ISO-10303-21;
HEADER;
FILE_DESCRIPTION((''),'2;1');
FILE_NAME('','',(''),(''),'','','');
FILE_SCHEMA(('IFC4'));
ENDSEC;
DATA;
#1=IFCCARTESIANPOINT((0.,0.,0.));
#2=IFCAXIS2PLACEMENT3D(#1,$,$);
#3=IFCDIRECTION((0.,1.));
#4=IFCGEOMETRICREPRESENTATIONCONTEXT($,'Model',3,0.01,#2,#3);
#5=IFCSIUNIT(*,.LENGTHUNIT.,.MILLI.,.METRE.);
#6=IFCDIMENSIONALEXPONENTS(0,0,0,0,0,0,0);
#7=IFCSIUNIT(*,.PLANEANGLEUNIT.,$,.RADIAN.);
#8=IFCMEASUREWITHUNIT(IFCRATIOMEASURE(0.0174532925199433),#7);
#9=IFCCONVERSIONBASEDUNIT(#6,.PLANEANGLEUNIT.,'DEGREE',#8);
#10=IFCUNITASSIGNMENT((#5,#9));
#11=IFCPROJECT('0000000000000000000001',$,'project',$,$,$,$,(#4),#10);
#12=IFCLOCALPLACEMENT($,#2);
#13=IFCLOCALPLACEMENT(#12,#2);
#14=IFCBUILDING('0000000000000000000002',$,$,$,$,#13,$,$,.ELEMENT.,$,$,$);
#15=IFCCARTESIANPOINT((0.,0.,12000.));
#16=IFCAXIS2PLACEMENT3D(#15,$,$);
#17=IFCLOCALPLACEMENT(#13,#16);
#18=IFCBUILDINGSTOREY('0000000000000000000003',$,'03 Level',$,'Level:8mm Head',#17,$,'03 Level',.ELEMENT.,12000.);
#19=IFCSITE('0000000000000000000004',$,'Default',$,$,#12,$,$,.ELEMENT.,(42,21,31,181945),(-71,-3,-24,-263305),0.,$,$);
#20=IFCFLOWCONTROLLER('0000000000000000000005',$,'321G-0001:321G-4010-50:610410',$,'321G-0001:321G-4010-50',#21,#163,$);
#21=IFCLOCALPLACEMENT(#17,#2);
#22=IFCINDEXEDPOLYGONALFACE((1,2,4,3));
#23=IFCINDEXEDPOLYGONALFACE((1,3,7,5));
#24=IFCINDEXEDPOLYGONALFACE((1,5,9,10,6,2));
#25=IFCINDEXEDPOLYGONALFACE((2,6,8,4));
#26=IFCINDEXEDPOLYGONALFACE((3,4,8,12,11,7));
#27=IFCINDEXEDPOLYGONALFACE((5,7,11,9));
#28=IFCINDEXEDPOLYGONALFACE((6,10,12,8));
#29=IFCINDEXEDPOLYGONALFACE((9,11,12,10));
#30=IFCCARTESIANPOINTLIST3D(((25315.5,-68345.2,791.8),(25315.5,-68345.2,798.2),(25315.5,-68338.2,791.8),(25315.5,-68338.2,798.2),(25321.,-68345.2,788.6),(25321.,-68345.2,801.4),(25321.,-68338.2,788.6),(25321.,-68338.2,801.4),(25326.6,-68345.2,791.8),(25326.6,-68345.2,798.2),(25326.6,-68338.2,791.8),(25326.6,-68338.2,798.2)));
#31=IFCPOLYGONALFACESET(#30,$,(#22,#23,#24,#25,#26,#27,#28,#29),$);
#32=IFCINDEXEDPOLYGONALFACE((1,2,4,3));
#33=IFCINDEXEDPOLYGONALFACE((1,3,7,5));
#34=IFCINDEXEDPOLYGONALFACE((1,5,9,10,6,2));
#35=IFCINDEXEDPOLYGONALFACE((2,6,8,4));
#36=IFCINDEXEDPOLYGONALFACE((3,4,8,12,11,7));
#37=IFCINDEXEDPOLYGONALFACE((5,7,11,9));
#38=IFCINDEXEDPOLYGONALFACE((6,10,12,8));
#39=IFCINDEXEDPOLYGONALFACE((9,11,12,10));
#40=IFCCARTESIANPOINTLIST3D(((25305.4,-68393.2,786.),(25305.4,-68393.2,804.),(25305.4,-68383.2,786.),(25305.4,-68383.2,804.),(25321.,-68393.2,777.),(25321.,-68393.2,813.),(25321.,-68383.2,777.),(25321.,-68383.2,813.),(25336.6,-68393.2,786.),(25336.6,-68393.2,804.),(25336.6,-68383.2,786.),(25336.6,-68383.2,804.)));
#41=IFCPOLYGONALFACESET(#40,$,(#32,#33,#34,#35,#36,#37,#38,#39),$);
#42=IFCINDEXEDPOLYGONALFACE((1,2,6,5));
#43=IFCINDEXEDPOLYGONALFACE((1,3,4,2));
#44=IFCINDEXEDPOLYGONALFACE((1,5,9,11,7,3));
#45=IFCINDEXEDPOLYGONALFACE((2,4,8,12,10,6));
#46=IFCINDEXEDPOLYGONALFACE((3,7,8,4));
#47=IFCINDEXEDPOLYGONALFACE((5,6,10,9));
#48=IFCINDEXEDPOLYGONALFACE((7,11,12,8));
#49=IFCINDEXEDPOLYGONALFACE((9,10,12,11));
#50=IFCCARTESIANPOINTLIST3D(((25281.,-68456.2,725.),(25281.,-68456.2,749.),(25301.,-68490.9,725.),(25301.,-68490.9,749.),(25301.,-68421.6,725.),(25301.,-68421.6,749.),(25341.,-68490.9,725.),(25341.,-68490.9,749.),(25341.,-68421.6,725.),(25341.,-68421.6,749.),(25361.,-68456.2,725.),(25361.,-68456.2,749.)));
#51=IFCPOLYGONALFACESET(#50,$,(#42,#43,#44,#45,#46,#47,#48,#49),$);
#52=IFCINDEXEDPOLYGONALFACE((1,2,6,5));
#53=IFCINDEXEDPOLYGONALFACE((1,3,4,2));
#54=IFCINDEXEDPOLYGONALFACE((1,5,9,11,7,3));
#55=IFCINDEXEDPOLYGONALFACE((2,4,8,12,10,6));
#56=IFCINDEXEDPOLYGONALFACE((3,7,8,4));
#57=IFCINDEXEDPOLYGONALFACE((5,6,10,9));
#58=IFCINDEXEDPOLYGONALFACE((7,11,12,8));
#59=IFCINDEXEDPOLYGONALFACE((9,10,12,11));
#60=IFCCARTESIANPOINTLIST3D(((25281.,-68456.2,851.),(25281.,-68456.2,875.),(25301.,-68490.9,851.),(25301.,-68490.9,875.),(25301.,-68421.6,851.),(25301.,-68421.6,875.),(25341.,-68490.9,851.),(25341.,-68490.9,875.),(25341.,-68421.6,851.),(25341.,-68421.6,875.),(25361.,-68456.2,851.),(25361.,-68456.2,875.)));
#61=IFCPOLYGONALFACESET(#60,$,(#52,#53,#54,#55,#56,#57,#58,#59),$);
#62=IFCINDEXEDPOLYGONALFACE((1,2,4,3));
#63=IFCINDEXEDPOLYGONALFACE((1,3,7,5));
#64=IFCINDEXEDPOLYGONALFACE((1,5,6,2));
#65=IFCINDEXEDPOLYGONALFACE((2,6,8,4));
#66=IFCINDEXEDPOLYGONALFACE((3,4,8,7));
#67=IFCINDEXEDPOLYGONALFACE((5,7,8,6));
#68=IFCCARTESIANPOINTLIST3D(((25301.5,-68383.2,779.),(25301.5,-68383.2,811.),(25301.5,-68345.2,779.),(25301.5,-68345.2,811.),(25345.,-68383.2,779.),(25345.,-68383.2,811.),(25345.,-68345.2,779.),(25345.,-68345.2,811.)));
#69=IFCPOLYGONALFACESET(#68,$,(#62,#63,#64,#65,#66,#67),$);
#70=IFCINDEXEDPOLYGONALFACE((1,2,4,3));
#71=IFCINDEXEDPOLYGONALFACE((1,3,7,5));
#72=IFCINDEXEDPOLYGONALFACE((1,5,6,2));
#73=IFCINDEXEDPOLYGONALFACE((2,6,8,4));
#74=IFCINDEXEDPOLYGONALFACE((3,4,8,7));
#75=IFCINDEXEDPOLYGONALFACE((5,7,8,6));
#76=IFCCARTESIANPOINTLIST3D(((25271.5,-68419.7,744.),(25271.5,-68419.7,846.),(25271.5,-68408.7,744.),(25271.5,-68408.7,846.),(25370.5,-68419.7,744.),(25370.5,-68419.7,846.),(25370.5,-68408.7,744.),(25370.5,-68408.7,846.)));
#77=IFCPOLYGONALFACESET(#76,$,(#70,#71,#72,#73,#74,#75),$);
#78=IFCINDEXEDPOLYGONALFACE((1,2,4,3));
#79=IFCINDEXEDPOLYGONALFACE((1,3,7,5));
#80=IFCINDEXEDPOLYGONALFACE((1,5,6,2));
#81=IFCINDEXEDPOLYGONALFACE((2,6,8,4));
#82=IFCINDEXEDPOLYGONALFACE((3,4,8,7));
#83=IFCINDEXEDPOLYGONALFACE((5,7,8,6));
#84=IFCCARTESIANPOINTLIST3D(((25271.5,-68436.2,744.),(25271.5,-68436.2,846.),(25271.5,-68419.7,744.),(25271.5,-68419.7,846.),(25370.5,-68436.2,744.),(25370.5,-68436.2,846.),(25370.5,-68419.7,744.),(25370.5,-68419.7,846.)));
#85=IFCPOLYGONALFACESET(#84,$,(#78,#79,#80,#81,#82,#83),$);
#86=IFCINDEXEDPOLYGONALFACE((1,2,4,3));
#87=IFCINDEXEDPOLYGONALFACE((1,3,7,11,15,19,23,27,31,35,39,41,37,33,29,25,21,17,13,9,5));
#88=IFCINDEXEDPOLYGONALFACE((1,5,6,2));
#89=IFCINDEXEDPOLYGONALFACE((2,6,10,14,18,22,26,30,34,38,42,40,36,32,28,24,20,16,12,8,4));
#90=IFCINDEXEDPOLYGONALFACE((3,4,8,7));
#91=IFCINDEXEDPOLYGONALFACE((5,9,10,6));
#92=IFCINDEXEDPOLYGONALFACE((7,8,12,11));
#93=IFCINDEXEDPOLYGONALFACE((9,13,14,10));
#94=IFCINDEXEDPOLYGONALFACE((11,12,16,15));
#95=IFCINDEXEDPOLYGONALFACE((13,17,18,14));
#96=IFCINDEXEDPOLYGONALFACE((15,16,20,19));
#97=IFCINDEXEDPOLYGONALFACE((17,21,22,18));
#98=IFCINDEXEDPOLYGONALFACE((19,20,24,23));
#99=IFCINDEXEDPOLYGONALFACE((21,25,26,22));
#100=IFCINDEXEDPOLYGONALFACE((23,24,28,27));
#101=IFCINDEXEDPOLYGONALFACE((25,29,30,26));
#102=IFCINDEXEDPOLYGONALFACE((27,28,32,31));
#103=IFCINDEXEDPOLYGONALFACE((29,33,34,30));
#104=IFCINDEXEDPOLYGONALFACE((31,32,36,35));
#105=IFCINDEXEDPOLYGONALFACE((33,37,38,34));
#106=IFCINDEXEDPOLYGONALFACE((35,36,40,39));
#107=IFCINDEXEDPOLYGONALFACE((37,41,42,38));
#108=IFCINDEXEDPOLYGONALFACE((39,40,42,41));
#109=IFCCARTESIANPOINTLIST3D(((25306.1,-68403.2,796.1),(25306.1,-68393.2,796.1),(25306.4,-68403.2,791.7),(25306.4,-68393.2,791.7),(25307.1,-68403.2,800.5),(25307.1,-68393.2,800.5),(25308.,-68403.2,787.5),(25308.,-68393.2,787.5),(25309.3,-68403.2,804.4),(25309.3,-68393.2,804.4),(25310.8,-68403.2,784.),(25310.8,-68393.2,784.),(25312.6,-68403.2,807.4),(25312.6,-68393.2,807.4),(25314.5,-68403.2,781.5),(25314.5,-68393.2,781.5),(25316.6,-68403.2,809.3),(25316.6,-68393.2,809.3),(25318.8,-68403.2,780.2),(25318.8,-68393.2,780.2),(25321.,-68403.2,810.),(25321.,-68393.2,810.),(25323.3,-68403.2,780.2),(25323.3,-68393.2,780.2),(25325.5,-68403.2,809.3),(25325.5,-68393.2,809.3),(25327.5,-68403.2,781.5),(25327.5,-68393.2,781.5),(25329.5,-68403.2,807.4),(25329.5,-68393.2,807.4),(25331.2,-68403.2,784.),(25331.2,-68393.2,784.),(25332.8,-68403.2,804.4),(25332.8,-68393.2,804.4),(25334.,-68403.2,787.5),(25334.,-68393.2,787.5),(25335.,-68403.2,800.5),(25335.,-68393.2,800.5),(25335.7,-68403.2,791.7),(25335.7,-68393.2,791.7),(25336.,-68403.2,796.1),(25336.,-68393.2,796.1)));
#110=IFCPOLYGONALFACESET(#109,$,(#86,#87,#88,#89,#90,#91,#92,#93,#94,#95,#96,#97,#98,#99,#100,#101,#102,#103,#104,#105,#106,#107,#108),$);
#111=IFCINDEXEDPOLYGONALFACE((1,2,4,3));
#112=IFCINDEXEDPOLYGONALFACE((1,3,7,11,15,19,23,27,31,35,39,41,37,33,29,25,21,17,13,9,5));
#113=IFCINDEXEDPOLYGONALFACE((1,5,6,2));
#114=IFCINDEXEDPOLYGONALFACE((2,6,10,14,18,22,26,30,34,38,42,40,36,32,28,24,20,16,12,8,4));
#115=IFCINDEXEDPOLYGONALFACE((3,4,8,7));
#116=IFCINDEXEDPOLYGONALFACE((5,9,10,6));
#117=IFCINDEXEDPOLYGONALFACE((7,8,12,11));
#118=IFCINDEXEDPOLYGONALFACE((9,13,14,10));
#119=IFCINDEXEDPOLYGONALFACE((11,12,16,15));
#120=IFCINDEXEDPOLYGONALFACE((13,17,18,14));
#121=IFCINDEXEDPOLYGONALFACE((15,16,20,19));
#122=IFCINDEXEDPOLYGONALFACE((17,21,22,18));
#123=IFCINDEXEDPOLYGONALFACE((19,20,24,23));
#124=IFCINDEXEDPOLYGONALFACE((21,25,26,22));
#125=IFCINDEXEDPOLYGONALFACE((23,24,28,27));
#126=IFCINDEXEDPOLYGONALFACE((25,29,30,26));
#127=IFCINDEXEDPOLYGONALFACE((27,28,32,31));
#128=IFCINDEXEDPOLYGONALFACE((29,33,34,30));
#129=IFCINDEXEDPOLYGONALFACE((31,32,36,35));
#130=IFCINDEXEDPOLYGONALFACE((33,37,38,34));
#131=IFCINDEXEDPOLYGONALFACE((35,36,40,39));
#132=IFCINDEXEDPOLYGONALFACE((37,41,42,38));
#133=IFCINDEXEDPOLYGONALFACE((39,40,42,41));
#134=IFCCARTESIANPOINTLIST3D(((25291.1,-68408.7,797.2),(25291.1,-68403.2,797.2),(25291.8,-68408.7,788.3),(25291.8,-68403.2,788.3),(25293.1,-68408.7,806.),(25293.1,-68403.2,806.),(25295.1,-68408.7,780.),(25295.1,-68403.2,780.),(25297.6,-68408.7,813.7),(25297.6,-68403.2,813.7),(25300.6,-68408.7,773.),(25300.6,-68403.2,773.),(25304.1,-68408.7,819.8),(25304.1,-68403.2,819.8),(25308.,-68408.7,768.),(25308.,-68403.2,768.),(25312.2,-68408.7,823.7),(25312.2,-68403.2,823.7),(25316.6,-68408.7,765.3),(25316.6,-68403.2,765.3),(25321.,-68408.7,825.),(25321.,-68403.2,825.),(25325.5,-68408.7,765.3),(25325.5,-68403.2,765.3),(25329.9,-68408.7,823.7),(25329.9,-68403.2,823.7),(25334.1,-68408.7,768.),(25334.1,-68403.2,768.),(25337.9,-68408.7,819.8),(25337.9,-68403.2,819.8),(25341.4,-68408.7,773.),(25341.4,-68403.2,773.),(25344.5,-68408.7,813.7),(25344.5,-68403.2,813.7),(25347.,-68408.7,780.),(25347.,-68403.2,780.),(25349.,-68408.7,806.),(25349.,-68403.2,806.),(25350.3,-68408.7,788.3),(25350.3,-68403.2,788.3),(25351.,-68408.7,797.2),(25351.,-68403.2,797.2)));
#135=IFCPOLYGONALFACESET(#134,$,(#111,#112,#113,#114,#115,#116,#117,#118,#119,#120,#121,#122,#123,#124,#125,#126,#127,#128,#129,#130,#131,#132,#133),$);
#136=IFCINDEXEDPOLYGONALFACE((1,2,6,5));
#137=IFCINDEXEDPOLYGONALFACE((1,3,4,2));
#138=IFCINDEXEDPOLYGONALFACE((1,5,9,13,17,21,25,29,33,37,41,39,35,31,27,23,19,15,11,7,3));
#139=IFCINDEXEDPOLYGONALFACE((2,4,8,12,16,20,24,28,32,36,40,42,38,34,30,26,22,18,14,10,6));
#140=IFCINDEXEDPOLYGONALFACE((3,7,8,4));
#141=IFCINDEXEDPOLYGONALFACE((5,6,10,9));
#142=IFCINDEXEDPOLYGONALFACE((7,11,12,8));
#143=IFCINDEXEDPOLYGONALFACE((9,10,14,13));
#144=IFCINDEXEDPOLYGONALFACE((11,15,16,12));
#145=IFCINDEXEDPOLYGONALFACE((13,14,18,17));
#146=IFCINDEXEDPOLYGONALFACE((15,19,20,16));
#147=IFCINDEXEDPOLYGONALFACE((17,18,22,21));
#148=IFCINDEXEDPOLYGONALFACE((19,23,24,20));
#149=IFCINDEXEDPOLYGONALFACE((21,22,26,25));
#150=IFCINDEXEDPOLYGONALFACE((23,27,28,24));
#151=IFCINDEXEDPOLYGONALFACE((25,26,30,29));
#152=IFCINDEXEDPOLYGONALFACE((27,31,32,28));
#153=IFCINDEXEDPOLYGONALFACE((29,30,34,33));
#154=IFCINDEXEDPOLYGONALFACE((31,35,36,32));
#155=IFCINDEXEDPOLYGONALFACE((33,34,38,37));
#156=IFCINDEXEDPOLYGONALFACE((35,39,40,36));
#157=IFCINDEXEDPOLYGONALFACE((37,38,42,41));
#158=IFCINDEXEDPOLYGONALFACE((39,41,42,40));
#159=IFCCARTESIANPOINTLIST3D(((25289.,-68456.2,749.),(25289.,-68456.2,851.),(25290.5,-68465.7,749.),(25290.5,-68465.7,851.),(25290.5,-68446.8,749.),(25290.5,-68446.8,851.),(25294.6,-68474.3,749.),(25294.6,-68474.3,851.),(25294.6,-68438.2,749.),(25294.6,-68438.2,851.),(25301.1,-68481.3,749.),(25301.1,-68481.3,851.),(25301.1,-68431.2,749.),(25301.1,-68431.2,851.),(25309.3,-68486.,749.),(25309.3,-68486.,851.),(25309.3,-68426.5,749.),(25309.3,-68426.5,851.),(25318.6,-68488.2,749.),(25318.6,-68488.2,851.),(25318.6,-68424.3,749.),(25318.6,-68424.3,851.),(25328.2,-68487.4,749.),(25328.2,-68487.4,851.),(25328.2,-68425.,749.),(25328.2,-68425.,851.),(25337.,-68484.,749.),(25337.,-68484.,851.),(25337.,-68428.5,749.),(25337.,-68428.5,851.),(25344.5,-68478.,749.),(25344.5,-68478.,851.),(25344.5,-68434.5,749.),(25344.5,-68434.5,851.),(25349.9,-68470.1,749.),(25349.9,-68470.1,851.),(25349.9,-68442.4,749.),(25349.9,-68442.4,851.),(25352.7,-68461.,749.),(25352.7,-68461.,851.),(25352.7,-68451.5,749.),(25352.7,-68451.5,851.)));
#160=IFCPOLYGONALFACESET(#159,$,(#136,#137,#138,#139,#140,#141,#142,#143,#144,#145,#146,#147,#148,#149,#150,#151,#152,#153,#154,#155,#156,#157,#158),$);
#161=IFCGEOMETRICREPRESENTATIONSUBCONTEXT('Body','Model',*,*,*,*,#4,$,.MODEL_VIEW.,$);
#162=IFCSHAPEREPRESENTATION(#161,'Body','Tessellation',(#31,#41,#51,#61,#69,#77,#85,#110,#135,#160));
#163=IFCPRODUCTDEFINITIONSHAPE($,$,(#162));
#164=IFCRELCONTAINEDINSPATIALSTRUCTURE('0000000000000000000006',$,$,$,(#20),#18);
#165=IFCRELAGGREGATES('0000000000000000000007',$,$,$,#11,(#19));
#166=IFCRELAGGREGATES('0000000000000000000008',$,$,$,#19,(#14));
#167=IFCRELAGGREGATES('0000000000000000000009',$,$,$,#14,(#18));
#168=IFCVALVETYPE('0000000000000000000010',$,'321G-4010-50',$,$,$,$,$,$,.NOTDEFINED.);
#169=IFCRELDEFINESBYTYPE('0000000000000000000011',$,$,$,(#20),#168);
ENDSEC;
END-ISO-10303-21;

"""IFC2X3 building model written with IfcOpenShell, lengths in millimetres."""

from ifc_helpers import new_model, entity, si_unit, converted_unit, direction, frame, frame_2d, origin, origin_2d_with_axis, place, context, subcontext, project, spatial, polyline, rectangle, circle, outline, extrude, source, transform, mapped, type_object, type_shapes, element, save


model = new_model("IFC2X3")

# Units and contexts
model_context = context("Model", 3, precision=0.01, world=origin(), true_north=direction((0.0, 1.0)))
body_context = subcontext(model_context, "Body", "Model", "MODEL_VIEW")
ifc_project = project(units=[si_unit("LENGTHUNIT", "METRE", prefix="MILLI"), converted_unit("PLANEANGLEUNIT", "DEGREE", entity("IfcRatioMeasure", 0.0174532925199433), si_unit("PLANEANGLEUNIT", "RADIAN"), dimensions=[0, 0, 0, 0, 0, 0, 0])], contexts=[model_context])

# Site, building, storey
site_placement = place(None, origin())
site = spatial("IfcSite", under=ifc_project, at=site_placement, Name="Default", CompositionType="ELEMENT", RefLatitude=(42, 21, 31, 181945), RefLongitude=(-71, -3, -24, -263305), RefElevation=0.0)
building_placement = place(site_placement, origin())
building = spatial("IfcBuilding", under=site, at=building_placement, CompositionType="ELEMENT")
storey_placement = place(building_placement, frame((0.0, 0.0, 12000.0)))
storey = spatial("IfcBuildingStorey", under=building, at=storey_placement, Name="03 Level", ObjectType="Level:8mm Head", LongName="03 Level", CompositionType="ELEMENT", Elevation=12000.0)

# Flow controller
valve_type_1 = type_object("IfcValveType", Name="321G-4010-50", PredefinedType="NOTDEFINED")
shared_shape_1 = source(origin(), body_context, "Body", "SweptSolid", [
    extrude(outline(polyline([(-3.2, -5.5), (3.2, -5.5), (6.4, 0.0), (3.2, 5.5), (-3.2, 5.5), (-6.4, 0.0), (-3.2, -5.5)])), frame((-5.0, 0.0, 111.0), z_axis=(0.0, 0.0, 1.0), x_axis=(0.5, 0.866025, 0.0)), (0.0, 0.0, 1.0), 7.0),
    extrude(outline(polyline([(-9.0, -15.6), (9.0, -15.6), (18.0, 0.0), (9.0, 15.6), (-9.0, 15.6), (-18.0, 0.0), (-9.0, -15.6)])), frame((-5.0, 0.0, 63.0), z_axis=(0.0, 0.0, 1.0), x_axis=(0.5, 0.866025, 0.0)), (0.0, 0.0, 1.0), 10.0),
    extrude(outline(polyline([(-20.0, -34.6), (20.0, -34.6), (40.0, 0.0), (20.0, 34.6), (-20.0, 34.6), (-40.0, 0.0), (-20.0, -34.6)])), frame((-75.0, 0.0, 0.0), z_axis=(1.0, 0.0, 0.0), x_axis=(0.0, -0.5, -0.866025)), (0.0, 0.0, 1.0), 24.0),
    extrude(outline(polyline([(-20.0, -34.6), (20.0, -34.6), (40.0, 0.0), (20.0, 34.6), (-20.0, 34.6), (-40.0, 0.0), (-20.0, -34.6)])), frame((51.0, 0.0, 0.0), z_axis=(1.0, 0.0, 0.0), x_axis=(0.0, -0.5, -0.866025)), (0.0, 0.0, 1.0), 24.0),
    extrude(rectangle(XDim=43.5, YDim=32.0, at=frame_2d((0.0, 0.0), x_axis=(1.0, 0.0))), frame((-5.0, 2.2, 73.0), z_axis=(0.0, 0.0, 1.0), x_axis=(0.0, -1.0, 0.0)), (0.0, 0.0, 1.0), 38.0),
    extrude(rectangle(XDim=99.0, YDim=102.0, at=origin_2d_with_axis()), frame((-5.0, 0.0, 36.5), z_axis=(0.0, 0.0, 1.0), x_axis=(0.0, -1.0, 0.0)), (0.0, 0.0, 1.0), 11.0),
    extrude(rectangle(XDim=99.0, YDim=102.0, at=origin_2d_with_axis()), frame((-5.0, 0.0, 20.0), z_axis=(0.0, 0.0, 1.0), x_axis=(0.0, -1.0, 0.0)), (0.0, 0.0, 1.0), 16.5),
    extrude(circle(Radius=15.0, at=frame_2d((0.0, 0.0), x_axis=(1.0, 0.0))), frame((-5.0, 0.0, 53.0)), (0.0, 0.0, 1.0), 10.0),
    extrude(circle(Radius=30.0, at=frame_2d((0.0, 0.0), x_axis=(1.0, 0.0))), frame((-5.0, 0.0, 47.5)), (0.0, 0.0, 1.0), 5.5),
    extrude(circle(Radius=32.0, at=frame_2d((0.0, 0.0), x_axis=(1.0, 0.0))), frame((-51.0, 0.0, 0.0), z_axis=(1.0, 0.0, 0.0), x_axis=(0.0, -1.0, 0.0)), (0.0, 0.0, 1.0), 102.0),
])
type_shapes(valve_type_1, [shared_shape_1])
flow_controller_1_placement = place(storey_placement, frame((25321.0, -68456.2, 800.0), z_axis=(0.0, 1.0, 0.0), x_axis=(0.0, 0.0, 1.0)))
element("IfcFlowController", 1, at=flow_controller_1_placement, inside=storey, type_object=valve_type_1, Name="321G-0001:321G-4010-50:610410", ObjectType="321G-0001:321G-4010-50", context=body_context, shape_type="MappedRepresentation", body=[
    mapped(shared_shape_1, transform((0.0, 0.0, 0.0), scale=1.0)),
])

save(model, "model.ifc")
